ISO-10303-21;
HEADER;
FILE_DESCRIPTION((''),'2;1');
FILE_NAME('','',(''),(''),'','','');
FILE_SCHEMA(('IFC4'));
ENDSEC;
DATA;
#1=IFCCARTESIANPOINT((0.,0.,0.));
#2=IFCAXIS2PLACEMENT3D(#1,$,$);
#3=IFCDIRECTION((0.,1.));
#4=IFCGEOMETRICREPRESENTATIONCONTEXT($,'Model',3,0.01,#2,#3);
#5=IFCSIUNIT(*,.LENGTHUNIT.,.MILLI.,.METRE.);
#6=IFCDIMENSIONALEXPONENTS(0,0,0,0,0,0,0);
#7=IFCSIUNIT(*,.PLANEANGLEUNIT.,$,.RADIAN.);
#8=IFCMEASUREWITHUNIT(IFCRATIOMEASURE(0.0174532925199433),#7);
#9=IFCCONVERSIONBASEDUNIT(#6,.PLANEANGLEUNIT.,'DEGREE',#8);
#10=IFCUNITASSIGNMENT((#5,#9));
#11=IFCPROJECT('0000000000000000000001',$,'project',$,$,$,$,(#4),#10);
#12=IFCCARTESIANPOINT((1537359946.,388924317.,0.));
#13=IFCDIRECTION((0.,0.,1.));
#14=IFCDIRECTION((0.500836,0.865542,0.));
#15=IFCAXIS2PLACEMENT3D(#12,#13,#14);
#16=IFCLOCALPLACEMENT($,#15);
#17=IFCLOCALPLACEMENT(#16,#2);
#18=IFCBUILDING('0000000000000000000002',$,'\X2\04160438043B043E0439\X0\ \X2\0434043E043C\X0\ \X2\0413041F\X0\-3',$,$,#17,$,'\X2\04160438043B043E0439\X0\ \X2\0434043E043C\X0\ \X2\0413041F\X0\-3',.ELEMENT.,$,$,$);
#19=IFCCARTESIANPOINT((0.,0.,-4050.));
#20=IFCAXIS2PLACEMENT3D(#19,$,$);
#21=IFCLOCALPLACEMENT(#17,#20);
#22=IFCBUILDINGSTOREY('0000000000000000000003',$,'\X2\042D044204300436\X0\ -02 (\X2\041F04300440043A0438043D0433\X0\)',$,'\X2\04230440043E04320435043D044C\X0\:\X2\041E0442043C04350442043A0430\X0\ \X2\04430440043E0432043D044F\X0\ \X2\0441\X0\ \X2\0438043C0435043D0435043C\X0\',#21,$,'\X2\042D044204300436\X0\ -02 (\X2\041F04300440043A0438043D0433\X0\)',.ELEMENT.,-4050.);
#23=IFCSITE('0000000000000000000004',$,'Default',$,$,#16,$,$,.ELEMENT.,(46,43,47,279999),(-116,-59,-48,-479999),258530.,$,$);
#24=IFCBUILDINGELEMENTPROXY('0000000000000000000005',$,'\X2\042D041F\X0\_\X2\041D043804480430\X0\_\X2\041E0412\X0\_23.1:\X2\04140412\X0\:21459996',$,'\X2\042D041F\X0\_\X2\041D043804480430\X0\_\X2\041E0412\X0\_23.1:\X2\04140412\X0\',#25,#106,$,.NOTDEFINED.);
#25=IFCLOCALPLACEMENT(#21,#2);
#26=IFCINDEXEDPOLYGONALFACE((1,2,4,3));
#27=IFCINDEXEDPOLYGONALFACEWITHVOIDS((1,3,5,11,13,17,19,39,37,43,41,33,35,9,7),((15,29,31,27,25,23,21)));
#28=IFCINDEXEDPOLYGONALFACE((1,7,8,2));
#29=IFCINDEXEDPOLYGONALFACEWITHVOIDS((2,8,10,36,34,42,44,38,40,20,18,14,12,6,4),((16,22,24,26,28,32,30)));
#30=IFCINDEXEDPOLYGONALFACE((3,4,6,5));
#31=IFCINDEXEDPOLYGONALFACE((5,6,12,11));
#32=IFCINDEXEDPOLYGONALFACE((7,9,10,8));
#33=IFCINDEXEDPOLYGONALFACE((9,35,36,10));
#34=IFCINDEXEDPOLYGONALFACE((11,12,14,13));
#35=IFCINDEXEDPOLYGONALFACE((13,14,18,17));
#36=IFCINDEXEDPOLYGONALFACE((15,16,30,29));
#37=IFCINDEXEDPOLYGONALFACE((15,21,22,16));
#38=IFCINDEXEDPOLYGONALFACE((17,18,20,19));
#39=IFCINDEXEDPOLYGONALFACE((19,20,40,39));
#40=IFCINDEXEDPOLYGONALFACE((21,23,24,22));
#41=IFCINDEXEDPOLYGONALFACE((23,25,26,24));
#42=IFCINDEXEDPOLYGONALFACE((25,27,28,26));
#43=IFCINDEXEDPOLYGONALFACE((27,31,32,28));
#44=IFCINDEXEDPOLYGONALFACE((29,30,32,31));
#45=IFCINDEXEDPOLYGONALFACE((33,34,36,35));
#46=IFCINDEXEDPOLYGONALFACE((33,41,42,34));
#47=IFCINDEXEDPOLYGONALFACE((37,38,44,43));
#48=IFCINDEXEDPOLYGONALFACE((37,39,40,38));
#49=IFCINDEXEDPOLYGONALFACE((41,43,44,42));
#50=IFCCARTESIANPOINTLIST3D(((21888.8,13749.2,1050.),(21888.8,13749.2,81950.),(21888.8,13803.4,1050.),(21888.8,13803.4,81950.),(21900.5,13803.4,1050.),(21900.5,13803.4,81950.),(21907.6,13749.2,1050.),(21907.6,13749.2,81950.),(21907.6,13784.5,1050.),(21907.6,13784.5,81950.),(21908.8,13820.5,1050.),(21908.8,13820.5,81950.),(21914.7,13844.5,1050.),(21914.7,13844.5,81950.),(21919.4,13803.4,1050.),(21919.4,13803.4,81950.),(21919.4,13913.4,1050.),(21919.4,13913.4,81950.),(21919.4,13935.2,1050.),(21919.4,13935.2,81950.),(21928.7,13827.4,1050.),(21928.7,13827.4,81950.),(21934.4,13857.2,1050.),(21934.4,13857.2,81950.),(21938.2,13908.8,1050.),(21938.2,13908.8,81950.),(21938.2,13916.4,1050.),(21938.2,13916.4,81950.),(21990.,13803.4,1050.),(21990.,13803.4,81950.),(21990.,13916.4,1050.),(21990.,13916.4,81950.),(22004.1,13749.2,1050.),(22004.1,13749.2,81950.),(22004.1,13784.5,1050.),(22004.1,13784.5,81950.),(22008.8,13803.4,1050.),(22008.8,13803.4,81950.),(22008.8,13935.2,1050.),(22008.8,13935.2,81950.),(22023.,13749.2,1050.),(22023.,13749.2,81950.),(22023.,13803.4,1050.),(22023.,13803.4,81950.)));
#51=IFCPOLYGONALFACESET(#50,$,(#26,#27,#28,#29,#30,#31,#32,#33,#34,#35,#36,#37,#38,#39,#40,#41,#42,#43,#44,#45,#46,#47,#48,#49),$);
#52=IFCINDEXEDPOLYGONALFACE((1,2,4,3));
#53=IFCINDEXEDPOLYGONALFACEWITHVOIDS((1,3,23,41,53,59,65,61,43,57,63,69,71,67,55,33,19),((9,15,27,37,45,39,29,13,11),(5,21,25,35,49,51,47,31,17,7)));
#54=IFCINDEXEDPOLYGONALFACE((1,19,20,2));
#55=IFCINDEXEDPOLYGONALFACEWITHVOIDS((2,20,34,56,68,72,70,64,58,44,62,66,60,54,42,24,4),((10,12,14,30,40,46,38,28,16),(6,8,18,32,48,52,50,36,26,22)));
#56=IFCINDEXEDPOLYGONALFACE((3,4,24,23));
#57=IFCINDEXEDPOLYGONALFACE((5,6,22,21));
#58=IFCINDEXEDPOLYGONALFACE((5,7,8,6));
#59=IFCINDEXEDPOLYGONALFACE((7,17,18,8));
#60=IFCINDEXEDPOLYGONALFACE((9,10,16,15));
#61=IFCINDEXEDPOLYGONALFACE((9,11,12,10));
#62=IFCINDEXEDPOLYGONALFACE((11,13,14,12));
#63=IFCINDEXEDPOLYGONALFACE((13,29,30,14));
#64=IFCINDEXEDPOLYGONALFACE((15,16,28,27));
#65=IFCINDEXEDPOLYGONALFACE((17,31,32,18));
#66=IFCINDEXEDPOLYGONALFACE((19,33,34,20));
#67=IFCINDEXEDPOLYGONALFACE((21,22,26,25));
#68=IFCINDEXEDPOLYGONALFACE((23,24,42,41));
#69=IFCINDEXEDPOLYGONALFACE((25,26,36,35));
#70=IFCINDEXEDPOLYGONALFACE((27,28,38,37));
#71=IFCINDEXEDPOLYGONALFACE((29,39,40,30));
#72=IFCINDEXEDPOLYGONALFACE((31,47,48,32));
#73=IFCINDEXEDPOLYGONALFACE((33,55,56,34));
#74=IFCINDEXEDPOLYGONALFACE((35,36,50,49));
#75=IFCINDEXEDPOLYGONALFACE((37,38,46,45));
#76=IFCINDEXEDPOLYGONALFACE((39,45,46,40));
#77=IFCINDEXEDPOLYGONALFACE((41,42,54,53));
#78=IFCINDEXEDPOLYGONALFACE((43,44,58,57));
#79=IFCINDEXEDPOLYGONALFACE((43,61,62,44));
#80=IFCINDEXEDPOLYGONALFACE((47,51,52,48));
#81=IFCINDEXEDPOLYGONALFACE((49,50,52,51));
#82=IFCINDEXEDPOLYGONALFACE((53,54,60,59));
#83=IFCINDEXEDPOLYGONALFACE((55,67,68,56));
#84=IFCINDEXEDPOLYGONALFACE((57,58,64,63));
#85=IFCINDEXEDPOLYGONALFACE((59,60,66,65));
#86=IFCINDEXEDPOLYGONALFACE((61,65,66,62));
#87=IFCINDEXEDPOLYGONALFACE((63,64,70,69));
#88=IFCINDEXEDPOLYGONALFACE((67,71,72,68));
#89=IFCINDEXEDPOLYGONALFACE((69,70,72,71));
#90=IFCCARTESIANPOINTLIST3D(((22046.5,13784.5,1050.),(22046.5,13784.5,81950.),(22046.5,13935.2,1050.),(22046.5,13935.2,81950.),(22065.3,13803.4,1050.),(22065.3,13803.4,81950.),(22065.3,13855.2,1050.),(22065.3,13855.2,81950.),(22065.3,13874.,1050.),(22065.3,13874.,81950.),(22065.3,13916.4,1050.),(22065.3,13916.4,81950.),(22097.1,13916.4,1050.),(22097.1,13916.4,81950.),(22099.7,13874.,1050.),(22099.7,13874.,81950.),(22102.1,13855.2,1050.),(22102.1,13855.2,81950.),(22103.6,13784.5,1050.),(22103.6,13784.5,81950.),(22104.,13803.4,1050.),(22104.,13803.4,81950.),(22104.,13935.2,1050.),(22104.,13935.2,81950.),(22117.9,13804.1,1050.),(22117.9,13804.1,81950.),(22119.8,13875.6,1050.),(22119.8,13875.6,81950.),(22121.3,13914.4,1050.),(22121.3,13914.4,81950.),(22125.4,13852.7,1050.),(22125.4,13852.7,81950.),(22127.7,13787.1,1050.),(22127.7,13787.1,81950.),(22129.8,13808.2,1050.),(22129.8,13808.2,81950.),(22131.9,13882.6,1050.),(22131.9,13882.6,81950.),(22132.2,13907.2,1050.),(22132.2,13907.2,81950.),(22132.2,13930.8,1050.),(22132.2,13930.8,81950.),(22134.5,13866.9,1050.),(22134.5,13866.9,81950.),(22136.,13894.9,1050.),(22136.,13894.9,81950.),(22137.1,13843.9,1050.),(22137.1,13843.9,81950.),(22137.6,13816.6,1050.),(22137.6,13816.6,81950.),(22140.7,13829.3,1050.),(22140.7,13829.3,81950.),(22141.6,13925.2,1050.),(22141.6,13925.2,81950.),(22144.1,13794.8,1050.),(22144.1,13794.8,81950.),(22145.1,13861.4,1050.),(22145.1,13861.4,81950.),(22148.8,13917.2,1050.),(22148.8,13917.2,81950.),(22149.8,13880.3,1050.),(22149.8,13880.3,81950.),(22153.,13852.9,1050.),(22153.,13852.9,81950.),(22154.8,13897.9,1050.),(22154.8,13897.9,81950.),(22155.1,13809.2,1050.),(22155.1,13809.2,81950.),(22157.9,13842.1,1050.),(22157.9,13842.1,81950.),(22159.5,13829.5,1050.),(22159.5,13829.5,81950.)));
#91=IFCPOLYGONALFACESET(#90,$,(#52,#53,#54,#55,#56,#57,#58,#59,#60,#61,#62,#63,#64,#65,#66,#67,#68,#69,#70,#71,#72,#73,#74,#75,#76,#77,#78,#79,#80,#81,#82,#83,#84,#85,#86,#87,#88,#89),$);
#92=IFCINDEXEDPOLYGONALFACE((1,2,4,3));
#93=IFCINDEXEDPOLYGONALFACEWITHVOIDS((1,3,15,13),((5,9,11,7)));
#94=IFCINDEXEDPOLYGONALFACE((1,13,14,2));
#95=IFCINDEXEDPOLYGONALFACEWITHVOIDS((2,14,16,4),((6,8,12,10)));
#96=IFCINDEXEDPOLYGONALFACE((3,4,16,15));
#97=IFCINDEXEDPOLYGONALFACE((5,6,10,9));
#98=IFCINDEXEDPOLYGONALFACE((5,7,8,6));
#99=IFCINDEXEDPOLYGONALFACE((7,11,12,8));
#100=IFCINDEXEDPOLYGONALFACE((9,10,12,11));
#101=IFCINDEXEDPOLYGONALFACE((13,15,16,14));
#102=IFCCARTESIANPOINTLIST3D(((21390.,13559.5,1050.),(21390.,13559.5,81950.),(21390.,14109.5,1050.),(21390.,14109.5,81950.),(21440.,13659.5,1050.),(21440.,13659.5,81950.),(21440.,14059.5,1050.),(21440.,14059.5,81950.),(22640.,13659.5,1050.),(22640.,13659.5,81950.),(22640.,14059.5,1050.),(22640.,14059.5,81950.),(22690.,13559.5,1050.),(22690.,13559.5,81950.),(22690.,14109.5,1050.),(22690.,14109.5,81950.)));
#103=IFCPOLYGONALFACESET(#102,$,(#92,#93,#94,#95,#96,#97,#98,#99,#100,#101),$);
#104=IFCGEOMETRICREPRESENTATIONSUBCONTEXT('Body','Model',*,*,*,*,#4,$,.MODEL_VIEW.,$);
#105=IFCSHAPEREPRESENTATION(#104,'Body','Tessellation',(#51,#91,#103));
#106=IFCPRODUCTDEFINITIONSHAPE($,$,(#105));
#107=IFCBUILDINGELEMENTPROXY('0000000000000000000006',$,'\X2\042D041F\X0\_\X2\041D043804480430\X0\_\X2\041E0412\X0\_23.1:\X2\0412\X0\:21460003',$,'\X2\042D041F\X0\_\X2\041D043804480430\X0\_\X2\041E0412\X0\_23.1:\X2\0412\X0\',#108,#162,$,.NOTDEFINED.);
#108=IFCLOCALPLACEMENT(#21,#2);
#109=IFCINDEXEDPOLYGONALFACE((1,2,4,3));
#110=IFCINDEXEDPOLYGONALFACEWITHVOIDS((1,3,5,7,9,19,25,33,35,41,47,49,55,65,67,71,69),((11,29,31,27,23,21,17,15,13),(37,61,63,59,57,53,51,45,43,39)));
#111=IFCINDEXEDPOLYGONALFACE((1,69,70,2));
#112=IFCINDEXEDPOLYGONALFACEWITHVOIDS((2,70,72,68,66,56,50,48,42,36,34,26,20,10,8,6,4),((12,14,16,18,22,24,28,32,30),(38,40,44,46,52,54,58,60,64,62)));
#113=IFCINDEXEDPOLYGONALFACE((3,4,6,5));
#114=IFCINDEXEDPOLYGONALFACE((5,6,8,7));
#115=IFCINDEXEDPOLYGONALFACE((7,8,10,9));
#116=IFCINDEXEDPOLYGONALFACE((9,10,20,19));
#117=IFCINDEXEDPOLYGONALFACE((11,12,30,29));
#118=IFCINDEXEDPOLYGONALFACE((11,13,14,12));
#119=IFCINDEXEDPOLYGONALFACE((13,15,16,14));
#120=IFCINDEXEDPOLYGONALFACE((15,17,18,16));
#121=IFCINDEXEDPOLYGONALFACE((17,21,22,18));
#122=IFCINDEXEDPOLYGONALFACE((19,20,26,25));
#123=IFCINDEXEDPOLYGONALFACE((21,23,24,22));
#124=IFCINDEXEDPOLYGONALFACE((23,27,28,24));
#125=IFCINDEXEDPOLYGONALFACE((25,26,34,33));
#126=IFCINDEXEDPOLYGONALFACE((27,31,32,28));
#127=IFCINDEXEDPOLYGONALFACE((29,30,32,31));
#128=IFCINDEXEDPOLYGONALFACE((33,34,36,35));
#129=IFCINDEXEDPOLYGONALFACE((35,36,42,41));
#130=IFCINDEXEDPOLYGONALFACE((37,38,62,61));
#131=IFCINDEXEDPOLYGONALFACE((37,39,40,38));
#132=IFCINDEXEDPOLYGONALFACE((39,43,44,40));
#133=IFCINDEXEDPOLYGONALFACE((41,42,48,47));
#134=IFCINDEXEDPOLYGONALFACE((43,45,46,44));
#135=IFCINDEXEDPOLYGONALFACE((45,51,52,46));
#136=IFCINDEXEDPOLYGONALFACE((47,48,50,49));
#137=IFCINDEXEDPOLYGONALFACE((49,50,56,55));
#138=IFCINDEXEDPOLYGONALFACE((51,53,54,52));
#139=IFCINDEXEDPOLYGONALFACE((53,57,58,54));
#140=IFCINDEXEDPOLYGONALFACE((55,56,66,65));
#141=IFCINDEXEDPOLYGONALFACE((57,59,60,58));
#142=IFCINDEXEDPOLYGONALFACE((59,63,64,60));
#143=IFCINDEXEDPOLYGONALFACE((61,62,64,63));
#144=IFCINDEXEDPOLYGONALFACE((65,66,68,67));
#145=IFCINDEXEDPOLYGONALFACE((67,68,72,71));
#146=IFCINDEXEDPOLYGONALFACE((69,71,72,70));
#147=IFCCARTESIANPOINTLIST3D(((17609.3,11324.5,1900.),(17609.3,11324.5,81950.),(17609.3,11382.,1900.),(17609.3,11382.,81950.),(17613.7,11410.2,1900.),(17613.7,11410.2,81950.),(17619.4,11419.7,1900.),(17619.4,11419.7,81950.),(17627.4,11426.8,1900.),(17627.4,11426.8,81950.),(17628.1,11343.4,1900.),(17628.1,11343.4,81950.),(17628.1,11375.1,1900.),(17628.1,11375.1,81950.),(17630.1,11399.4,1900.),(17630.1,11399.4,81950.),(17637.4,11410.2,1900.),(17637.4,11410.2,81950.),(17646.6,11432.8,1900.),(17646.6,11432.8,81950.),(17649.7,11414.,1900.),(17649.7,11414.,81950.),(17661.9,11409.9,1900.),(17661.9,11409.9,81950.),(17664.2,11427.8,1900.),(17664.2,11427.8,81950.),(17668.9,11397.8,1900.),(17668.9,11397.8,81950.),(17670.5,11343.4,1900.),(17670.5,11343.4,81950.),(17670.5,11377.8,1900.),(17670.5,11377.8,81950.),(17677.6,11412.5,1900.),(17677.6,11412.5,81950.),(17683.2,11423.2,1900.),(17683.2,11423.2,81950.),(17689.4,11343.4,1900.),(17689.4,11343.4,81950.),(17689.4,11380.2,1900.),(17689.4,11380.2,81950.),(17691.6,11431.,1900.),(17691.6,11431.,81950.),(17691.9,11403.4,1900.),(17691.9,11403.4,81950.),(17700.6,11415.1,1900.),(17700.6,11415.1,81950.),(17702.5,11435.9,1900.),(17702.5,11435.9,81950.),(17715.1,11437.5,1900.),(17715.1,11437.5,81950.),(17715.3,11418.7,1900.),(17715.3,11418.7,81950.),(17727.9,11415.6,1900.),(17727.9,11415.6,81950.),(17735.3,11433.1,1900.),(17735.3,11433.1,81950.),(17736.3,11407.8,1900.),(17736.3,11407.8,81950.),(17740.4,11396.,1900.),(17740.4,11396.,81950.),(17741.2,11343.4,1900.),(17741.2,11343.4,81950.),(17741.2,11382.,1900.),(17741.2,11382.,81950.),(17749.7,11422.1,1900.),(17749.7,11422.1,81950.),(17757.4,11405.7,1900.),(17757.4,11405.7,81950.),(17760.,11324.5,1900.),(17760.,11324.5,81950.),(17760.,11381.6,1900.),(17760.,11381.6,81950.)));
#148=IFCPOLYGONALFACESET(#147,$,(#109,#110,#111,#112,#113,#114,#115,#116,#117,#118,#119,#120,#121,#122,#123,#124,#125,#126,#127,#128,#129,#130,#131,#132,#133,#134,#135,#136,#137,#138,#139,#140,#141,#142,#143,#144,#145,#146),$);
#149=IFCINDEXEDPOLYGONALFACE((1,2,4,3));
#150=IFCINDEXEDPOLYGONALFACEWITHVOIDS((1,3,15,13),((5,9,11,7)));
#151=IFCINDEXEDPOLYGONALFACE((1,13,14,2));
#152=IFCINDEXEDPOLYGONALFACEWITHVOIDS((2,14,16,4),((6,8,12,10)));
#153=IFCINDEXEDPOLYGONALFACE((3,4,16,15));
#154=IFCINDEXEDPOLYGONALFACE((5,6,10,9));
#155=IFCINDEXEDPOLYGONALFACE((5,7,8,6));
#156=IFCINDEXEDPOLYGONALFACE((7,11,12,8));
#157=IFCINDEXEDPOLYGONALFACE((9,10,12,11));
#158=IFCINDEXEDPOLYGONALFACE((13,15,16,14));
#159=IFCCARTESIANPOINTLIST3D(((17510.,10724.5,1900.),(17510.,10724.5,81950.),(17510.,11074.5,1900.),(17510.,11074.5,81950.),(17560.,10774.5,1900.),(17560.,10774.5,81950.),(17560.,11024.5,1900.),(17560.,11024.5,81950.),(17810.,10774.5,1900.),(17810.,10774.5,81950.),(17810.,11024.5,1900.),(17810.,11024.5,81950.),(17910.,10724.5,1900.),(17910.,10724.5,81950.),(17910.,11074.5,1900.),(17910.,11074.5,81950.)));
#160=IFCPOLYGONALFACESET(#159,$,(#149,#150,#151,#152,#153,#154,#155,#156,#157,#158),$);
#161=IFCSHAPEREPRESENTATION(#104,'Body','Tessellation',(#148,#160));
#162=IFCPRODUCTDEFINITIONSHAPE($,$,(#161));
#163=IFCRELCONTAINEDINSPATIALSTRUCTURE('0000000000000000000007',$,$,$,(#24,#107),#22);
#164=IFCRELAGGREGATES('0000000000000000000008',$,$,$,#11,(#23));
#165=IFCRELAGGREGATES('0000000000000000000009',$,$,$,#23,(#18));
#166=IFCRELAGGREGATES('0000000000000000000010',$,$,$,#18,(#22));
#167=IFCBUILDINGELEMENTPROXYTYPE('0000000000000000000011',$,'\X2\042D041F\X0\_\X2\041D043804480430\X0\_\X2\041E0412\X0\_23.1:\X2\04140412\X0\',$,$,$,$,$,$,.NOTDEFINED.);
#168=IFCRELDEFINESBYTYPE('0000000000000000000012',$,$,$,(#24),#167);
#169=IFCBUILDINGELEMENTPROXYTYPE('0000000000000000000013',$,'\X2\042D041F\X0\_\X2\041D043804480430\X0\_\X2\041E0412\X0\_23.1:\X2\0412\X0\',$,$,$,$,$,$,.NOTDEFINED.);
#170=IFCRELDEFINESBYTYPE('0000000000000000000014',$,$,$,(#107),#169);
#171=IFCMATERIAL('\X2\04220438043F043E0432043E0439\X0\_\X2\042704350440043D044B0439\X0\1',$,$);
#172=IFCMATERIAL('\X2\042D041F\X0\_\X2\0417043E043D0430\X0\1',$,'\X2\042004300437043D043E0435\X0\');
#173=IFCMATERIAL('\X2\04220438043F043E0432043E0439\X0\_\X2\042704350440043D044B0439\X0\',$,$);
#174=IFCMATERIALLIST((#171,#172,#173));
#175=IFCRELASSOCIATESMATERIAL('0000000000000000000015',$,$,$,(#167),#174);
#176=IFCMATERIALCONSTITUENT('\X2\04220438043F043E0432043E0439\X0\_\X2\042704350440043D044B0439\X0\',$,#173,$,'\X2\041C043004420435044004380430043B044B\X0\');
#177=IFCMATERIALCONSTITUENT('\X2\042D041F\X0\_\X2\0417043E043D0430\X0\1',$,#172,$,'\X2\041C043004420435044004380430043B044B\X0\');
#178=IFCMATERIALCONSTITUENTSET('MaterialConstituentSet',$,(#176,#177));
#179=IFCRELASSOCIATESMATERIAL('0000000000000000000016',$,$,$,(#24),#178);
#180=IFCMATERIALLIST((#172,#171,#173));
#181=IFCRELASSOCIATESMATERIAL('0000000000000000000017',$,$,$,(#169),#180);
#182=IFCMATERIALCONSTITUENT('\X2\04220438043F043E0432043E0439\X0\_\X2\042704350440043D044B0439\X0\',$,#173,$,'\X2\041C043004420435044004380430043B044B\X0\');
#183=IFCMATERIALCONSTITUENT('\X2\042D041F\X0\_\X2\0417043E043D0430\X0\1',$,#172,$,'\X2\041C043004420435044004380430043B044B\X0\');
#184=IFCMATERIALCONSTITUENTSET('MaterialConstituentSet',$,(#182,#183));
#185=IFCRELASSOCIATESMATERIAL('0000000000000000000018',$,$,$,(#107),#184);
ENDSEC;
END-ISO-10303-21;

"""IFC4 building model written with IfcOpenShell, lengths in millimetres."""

from ifc_helpers import new_model, entity, si_unit, converted_unit, direction, frame, origin, place, context, subcontext, project, spatial, polyline, outline, extrude, source, transform, mapped, material, material_list, constituent, constituent_set, type_object, type_shapes, element, save


model = new_model("IFC4")

# Units and contexts
model_context = context("Model", 3, precision=0.01, world=origin(), true_north=direction((0.0, 1.0)))
body_context = subcontext(model_context, "Body", "Model", "MODEL_VIEW")
ifc_project = project(units=[si_unit("LENGTHUNIT", "METRE", prefix="MILLI"), converted_unit("PLANEANGLEUNIT", "DEGREE", entity("IfcRatioMeasure", 0.0174532925199433), si_unit("PLANEANGLEUNIT", "RADIAN"), dimensions=[0, 0, 0, 0, 0, 0, 0])], contexts=[model_context])

# Site, building, storey
site_placement = place(None, frame((1537359946.0, 388924317.0, 0.0), z_axis=(0.0, 0.0, 1.0), x_axis=(0.500836, 0.865542, 0.0)))
site = spatial("IfcSite", under=ifc_project, at=site_placement, Name="Default", CompositionType="ELEMENT", RefLatitude=(46, 43, 47, 279999), RefLongitude=(-116, -59, -48, -479999), RefElevation=258530.0)
building_placement = place(site_placement, origin())
building = spatial("IfcBuilding", under=site, at=building_placement, Name="Жилой дом ГП-3", LongName="Жилой дом ГП-3", CompositionType="ELEMENT")
storey_placement = place(building_placement, frame((0.0, 0.0, -4050.0)))
storey = spatial("IfcBuildingStorey", under=building, at=storey_placement, Name="Этаж -02 (Паркинг)", ObjectType="Уровень:Отметка уровня с именем", LongName="Этаж -02 (Паркинг)", CompositionType="ELEMENT", Elevation=-4050.0)

# Building element proxies
ifc_material_1 = material(Name="Типовой_Черный")
ifc_material_2 = material(Name="ЭП_Зона1", Category="Разное")
ifc_material_3 = material(Name="Типовой_Черный1")
ifc_constituent_1 = constituent(ifc_material_1, Name="Типовой_Черный", Category="Материалы")
ifc_constituent_2 = constituent(ifc_material_2, Name="ЭП_Зона1", Category="Материалы")
ifc_constituent_set_1 = constituent_set(constituents=[ifc_constituent_1, ifc_constituent_2], Name="MaterialConstituentSet")
ifc_material_list_1 = material_list([ifc_material_3, ifc_material_2, ifc_material_1])
building_element_proxy_type_1 = type_object("IfcBuildingElementProxyType", Name="ЭП_Ниша_ОВ_23.1:ДВ", PredefinedType="NOTDEFINED", material=ifc_material_list_1)
shared_shape_1 = source(origin(), body_context, "Body", "SweptSolid", [
    extrude(outline(polyline([(-120.0, 29.1), (-120.0, -60.4), (11.8, -60.4), (11.8, -74.5), (66.0, -74.5), (66.0, -55.6), (30.7, -55.6), (30.7, 40.9), (66.0, 40.9), (66.0, 59.7), (11.8, 59.7), (11.8, 48.0), (-5.2, 39.7), (-29.3, 33.8), (-98.2, 29.1), (-120.0, 29.1)]), holes=[polyline([(-101.2, -41.5), (-101.2, 10.3), (-93.6, 10.3), (-42.0, 14.1), (-12.2, 19.8), (11.8, 29.1), (11.8, -41.5), (-101.2, -41.5)])]), frame((508.5, -244.3, -3000.0), z_axis=(0.0, 0.0, -1.0), x_axis=(0.0, -1.0, 0.0)), (0.0, 0.0, -1.0), 80900.0),
    extrude(outline(polyline([(-83.2, -76.3), (-26.1, -76.3), (-2.0, -73.7), (14.4, -66.1), (25.4, -51.7), (29.8, -31.4), (28.2, -18.8), (23.3, -8.0), (15.5, 0.5), (4.8, 6.1), (20.1, 19.4), (25.1, 37.0), (19.1, 56.3), (11.9, 64.3), (2.5, 69.9), (-25.7, 74.4), (-83.2, 74.4), (-83.2, -76.3)]), holes=[polyline([(-64.3, 13.1), (-64.3, 55.5), (-32.6, 55.5), (-8.4, 53.6), (2.5, 46.3), (6.3, 34.0), (2.2, 21.7), (-9.9, 14.8), (-29.9, 13.1), (-64.3, 13.1)]), polyline([(-64.3, -57.5), (-64.3, -5.7), (-27.6, -5.7), (-4.3, -8.2), (7.4, -16.9), (11.0, -31.6), (7.9, -44.3), (0.1, -52.7), (-11.7, -56.8), (-25.7, -57.5), (-64.3, -57.5)])]), frame((689.7, -198.7, -3000.0)), (0.0, 0.0, 1.0), 80900.0),
    extrude(outline(polyline([(-650.0, -275.0), (650.0, -275.0), (650.0, 275.0), (-650.0, 275.0), (-650.0, -275.0)]), holes=[polyline([(600.0, 225.0), (600.0, -175.0), (-600.0, -175.0), (-600.0, 225.0), (600.0, 225.0)])]), frame((600.0, -225.0, -3000.0)), (0.0, 0.0, 1.0), 80900.0),
])
type_shapes(building_element_proxy_type_1, [shared_shape_1])
proxy_1_placement = place(storey_placement, frame((21440.0, 14059.5, 4050.0)))
element("IfcBuildingElementProxy", 1, at=proxy_1_placement, inside=storey, type_object=building_element_proxy_type_1, material=ifc_constituent_set_1, Name="ЭП_Ниша_ОВ_23.1:ДВ:21459996", ObjectType="ЭП_Ниша_ОВ_23.1:ДВ", PredefinedType="NOTDEFINED", context=body_context, shape_type="MappedRepresentation", body=[
    mapped(shared_shape_1, transform((0.0, 0.0, 0.0), scale=1.0)),
])
ifc_constituent_3 = constituent(ifc_material_1, Name="Типовой_Черный", Category="Материалы")
ifc_constituent_4 = constituent(ifc_material_2, Name="ЭП_Зона1", Category="Материалы")
ifc_constituent_set_2 = constituent_set(constituents=[ifc_constituent_3, ifc_constituent_4], Name="MaterialConstituentSet")
ifc_material_list_2 = material_list([ifc_material_2, ifc_material_3, ifc_material_1])
building_element_proxy_type_2 = type_object("IfcBuildingElementProxyType", Name="ЭП_Ниша_ОВ_23.1:В", PredefinedType="NOTDEFINED", material=ifc_material_list_2)
shared_shape_2 = source(origin(), body_context, "Body", "SweptSolid", [
    extrude(outline(polyline([(-83.2, -76.3), (-26.1, -76.3), (-2.0, -73.7), (14.4, -66.1), (25.4, -51.7), (29.8, -31.4), (28.2, -18.8), (23.3, -8.0), (15.5, 0.5), (4.8, 6.1), (20.1, 19.4), (25.1, 37.0), (19.1, 56.3), (11.9, 64.3), (2.5, 69.9), (-25.7, 74.4), (-83.2, 74.4), (-83.2, -76.3)]), holes=[polyline([(-64.3, 13.1), (-64.3, 55.5), (-32.6, 55.5), (-8.4, 53.6), (2.5, 46.3), (6.3, 34.0), (2.2, 21.7), (-9.9, 14.8), (-29.9, 13.1), (-64.3, 13.1)]), polyline([(-64.3, -57.5), (-64.3, -5.7), (-27.6, -5.7), (-4.3, -8.2), (7.4, -16.9), (11.0, -31.6), (7.9, -44.3), (0.1, -52.7), (-11.7, -56.8), (-25.7, -57.5), (-64.3, -57.5)])]), frame((683.2, 226.3, 0.0)), (0.0, 0.0, 1.0), 80050.0),
    extrude(outline(polyline([(-175.0, -200.0), (175.0, -200.0), (175.0, 200.0), (-175.0, 200.0), (-175.0, -200.0)]), holes=[polyline([(125.0, 150.0), (125.0, -100.0), (-125.0, -100.0), (-125.0, 150.0), (125.0, 150.0)])]), frame((175.0, 200.0, 0.0)), (0.0, 0.0, 1.0), 80050.0),
])
type_shapes(building_element_proxy_type_2, [shared_shape_2])
proxy_2_placement = place(storey_placement, frame((17910.0, 10724.5, 1900.0), z_axis=(0.0, 0.0, 1.0), x_axis=(0.0, 1.0, 0.0)))
element("IfcBuildingElementProxy", 2, at=proxy_2_placement, inside=storey, type_object=building_element_proxy_type_2, material=ifc_constituent_set_2, Name="ЭП_Ниша_ОВ_23.1:В:21460003", ObjectType="ЭП_Ниша_ОВ_23.1:В", PredefinedType="NOTDEFINED", context=body_context, shape_type="MappedRepresentation", body=[
    mapped(shared_shape_2, transform((0.0, 0.0, 0.0), scale=1.0)),
])

save(model, "model.ifc")
